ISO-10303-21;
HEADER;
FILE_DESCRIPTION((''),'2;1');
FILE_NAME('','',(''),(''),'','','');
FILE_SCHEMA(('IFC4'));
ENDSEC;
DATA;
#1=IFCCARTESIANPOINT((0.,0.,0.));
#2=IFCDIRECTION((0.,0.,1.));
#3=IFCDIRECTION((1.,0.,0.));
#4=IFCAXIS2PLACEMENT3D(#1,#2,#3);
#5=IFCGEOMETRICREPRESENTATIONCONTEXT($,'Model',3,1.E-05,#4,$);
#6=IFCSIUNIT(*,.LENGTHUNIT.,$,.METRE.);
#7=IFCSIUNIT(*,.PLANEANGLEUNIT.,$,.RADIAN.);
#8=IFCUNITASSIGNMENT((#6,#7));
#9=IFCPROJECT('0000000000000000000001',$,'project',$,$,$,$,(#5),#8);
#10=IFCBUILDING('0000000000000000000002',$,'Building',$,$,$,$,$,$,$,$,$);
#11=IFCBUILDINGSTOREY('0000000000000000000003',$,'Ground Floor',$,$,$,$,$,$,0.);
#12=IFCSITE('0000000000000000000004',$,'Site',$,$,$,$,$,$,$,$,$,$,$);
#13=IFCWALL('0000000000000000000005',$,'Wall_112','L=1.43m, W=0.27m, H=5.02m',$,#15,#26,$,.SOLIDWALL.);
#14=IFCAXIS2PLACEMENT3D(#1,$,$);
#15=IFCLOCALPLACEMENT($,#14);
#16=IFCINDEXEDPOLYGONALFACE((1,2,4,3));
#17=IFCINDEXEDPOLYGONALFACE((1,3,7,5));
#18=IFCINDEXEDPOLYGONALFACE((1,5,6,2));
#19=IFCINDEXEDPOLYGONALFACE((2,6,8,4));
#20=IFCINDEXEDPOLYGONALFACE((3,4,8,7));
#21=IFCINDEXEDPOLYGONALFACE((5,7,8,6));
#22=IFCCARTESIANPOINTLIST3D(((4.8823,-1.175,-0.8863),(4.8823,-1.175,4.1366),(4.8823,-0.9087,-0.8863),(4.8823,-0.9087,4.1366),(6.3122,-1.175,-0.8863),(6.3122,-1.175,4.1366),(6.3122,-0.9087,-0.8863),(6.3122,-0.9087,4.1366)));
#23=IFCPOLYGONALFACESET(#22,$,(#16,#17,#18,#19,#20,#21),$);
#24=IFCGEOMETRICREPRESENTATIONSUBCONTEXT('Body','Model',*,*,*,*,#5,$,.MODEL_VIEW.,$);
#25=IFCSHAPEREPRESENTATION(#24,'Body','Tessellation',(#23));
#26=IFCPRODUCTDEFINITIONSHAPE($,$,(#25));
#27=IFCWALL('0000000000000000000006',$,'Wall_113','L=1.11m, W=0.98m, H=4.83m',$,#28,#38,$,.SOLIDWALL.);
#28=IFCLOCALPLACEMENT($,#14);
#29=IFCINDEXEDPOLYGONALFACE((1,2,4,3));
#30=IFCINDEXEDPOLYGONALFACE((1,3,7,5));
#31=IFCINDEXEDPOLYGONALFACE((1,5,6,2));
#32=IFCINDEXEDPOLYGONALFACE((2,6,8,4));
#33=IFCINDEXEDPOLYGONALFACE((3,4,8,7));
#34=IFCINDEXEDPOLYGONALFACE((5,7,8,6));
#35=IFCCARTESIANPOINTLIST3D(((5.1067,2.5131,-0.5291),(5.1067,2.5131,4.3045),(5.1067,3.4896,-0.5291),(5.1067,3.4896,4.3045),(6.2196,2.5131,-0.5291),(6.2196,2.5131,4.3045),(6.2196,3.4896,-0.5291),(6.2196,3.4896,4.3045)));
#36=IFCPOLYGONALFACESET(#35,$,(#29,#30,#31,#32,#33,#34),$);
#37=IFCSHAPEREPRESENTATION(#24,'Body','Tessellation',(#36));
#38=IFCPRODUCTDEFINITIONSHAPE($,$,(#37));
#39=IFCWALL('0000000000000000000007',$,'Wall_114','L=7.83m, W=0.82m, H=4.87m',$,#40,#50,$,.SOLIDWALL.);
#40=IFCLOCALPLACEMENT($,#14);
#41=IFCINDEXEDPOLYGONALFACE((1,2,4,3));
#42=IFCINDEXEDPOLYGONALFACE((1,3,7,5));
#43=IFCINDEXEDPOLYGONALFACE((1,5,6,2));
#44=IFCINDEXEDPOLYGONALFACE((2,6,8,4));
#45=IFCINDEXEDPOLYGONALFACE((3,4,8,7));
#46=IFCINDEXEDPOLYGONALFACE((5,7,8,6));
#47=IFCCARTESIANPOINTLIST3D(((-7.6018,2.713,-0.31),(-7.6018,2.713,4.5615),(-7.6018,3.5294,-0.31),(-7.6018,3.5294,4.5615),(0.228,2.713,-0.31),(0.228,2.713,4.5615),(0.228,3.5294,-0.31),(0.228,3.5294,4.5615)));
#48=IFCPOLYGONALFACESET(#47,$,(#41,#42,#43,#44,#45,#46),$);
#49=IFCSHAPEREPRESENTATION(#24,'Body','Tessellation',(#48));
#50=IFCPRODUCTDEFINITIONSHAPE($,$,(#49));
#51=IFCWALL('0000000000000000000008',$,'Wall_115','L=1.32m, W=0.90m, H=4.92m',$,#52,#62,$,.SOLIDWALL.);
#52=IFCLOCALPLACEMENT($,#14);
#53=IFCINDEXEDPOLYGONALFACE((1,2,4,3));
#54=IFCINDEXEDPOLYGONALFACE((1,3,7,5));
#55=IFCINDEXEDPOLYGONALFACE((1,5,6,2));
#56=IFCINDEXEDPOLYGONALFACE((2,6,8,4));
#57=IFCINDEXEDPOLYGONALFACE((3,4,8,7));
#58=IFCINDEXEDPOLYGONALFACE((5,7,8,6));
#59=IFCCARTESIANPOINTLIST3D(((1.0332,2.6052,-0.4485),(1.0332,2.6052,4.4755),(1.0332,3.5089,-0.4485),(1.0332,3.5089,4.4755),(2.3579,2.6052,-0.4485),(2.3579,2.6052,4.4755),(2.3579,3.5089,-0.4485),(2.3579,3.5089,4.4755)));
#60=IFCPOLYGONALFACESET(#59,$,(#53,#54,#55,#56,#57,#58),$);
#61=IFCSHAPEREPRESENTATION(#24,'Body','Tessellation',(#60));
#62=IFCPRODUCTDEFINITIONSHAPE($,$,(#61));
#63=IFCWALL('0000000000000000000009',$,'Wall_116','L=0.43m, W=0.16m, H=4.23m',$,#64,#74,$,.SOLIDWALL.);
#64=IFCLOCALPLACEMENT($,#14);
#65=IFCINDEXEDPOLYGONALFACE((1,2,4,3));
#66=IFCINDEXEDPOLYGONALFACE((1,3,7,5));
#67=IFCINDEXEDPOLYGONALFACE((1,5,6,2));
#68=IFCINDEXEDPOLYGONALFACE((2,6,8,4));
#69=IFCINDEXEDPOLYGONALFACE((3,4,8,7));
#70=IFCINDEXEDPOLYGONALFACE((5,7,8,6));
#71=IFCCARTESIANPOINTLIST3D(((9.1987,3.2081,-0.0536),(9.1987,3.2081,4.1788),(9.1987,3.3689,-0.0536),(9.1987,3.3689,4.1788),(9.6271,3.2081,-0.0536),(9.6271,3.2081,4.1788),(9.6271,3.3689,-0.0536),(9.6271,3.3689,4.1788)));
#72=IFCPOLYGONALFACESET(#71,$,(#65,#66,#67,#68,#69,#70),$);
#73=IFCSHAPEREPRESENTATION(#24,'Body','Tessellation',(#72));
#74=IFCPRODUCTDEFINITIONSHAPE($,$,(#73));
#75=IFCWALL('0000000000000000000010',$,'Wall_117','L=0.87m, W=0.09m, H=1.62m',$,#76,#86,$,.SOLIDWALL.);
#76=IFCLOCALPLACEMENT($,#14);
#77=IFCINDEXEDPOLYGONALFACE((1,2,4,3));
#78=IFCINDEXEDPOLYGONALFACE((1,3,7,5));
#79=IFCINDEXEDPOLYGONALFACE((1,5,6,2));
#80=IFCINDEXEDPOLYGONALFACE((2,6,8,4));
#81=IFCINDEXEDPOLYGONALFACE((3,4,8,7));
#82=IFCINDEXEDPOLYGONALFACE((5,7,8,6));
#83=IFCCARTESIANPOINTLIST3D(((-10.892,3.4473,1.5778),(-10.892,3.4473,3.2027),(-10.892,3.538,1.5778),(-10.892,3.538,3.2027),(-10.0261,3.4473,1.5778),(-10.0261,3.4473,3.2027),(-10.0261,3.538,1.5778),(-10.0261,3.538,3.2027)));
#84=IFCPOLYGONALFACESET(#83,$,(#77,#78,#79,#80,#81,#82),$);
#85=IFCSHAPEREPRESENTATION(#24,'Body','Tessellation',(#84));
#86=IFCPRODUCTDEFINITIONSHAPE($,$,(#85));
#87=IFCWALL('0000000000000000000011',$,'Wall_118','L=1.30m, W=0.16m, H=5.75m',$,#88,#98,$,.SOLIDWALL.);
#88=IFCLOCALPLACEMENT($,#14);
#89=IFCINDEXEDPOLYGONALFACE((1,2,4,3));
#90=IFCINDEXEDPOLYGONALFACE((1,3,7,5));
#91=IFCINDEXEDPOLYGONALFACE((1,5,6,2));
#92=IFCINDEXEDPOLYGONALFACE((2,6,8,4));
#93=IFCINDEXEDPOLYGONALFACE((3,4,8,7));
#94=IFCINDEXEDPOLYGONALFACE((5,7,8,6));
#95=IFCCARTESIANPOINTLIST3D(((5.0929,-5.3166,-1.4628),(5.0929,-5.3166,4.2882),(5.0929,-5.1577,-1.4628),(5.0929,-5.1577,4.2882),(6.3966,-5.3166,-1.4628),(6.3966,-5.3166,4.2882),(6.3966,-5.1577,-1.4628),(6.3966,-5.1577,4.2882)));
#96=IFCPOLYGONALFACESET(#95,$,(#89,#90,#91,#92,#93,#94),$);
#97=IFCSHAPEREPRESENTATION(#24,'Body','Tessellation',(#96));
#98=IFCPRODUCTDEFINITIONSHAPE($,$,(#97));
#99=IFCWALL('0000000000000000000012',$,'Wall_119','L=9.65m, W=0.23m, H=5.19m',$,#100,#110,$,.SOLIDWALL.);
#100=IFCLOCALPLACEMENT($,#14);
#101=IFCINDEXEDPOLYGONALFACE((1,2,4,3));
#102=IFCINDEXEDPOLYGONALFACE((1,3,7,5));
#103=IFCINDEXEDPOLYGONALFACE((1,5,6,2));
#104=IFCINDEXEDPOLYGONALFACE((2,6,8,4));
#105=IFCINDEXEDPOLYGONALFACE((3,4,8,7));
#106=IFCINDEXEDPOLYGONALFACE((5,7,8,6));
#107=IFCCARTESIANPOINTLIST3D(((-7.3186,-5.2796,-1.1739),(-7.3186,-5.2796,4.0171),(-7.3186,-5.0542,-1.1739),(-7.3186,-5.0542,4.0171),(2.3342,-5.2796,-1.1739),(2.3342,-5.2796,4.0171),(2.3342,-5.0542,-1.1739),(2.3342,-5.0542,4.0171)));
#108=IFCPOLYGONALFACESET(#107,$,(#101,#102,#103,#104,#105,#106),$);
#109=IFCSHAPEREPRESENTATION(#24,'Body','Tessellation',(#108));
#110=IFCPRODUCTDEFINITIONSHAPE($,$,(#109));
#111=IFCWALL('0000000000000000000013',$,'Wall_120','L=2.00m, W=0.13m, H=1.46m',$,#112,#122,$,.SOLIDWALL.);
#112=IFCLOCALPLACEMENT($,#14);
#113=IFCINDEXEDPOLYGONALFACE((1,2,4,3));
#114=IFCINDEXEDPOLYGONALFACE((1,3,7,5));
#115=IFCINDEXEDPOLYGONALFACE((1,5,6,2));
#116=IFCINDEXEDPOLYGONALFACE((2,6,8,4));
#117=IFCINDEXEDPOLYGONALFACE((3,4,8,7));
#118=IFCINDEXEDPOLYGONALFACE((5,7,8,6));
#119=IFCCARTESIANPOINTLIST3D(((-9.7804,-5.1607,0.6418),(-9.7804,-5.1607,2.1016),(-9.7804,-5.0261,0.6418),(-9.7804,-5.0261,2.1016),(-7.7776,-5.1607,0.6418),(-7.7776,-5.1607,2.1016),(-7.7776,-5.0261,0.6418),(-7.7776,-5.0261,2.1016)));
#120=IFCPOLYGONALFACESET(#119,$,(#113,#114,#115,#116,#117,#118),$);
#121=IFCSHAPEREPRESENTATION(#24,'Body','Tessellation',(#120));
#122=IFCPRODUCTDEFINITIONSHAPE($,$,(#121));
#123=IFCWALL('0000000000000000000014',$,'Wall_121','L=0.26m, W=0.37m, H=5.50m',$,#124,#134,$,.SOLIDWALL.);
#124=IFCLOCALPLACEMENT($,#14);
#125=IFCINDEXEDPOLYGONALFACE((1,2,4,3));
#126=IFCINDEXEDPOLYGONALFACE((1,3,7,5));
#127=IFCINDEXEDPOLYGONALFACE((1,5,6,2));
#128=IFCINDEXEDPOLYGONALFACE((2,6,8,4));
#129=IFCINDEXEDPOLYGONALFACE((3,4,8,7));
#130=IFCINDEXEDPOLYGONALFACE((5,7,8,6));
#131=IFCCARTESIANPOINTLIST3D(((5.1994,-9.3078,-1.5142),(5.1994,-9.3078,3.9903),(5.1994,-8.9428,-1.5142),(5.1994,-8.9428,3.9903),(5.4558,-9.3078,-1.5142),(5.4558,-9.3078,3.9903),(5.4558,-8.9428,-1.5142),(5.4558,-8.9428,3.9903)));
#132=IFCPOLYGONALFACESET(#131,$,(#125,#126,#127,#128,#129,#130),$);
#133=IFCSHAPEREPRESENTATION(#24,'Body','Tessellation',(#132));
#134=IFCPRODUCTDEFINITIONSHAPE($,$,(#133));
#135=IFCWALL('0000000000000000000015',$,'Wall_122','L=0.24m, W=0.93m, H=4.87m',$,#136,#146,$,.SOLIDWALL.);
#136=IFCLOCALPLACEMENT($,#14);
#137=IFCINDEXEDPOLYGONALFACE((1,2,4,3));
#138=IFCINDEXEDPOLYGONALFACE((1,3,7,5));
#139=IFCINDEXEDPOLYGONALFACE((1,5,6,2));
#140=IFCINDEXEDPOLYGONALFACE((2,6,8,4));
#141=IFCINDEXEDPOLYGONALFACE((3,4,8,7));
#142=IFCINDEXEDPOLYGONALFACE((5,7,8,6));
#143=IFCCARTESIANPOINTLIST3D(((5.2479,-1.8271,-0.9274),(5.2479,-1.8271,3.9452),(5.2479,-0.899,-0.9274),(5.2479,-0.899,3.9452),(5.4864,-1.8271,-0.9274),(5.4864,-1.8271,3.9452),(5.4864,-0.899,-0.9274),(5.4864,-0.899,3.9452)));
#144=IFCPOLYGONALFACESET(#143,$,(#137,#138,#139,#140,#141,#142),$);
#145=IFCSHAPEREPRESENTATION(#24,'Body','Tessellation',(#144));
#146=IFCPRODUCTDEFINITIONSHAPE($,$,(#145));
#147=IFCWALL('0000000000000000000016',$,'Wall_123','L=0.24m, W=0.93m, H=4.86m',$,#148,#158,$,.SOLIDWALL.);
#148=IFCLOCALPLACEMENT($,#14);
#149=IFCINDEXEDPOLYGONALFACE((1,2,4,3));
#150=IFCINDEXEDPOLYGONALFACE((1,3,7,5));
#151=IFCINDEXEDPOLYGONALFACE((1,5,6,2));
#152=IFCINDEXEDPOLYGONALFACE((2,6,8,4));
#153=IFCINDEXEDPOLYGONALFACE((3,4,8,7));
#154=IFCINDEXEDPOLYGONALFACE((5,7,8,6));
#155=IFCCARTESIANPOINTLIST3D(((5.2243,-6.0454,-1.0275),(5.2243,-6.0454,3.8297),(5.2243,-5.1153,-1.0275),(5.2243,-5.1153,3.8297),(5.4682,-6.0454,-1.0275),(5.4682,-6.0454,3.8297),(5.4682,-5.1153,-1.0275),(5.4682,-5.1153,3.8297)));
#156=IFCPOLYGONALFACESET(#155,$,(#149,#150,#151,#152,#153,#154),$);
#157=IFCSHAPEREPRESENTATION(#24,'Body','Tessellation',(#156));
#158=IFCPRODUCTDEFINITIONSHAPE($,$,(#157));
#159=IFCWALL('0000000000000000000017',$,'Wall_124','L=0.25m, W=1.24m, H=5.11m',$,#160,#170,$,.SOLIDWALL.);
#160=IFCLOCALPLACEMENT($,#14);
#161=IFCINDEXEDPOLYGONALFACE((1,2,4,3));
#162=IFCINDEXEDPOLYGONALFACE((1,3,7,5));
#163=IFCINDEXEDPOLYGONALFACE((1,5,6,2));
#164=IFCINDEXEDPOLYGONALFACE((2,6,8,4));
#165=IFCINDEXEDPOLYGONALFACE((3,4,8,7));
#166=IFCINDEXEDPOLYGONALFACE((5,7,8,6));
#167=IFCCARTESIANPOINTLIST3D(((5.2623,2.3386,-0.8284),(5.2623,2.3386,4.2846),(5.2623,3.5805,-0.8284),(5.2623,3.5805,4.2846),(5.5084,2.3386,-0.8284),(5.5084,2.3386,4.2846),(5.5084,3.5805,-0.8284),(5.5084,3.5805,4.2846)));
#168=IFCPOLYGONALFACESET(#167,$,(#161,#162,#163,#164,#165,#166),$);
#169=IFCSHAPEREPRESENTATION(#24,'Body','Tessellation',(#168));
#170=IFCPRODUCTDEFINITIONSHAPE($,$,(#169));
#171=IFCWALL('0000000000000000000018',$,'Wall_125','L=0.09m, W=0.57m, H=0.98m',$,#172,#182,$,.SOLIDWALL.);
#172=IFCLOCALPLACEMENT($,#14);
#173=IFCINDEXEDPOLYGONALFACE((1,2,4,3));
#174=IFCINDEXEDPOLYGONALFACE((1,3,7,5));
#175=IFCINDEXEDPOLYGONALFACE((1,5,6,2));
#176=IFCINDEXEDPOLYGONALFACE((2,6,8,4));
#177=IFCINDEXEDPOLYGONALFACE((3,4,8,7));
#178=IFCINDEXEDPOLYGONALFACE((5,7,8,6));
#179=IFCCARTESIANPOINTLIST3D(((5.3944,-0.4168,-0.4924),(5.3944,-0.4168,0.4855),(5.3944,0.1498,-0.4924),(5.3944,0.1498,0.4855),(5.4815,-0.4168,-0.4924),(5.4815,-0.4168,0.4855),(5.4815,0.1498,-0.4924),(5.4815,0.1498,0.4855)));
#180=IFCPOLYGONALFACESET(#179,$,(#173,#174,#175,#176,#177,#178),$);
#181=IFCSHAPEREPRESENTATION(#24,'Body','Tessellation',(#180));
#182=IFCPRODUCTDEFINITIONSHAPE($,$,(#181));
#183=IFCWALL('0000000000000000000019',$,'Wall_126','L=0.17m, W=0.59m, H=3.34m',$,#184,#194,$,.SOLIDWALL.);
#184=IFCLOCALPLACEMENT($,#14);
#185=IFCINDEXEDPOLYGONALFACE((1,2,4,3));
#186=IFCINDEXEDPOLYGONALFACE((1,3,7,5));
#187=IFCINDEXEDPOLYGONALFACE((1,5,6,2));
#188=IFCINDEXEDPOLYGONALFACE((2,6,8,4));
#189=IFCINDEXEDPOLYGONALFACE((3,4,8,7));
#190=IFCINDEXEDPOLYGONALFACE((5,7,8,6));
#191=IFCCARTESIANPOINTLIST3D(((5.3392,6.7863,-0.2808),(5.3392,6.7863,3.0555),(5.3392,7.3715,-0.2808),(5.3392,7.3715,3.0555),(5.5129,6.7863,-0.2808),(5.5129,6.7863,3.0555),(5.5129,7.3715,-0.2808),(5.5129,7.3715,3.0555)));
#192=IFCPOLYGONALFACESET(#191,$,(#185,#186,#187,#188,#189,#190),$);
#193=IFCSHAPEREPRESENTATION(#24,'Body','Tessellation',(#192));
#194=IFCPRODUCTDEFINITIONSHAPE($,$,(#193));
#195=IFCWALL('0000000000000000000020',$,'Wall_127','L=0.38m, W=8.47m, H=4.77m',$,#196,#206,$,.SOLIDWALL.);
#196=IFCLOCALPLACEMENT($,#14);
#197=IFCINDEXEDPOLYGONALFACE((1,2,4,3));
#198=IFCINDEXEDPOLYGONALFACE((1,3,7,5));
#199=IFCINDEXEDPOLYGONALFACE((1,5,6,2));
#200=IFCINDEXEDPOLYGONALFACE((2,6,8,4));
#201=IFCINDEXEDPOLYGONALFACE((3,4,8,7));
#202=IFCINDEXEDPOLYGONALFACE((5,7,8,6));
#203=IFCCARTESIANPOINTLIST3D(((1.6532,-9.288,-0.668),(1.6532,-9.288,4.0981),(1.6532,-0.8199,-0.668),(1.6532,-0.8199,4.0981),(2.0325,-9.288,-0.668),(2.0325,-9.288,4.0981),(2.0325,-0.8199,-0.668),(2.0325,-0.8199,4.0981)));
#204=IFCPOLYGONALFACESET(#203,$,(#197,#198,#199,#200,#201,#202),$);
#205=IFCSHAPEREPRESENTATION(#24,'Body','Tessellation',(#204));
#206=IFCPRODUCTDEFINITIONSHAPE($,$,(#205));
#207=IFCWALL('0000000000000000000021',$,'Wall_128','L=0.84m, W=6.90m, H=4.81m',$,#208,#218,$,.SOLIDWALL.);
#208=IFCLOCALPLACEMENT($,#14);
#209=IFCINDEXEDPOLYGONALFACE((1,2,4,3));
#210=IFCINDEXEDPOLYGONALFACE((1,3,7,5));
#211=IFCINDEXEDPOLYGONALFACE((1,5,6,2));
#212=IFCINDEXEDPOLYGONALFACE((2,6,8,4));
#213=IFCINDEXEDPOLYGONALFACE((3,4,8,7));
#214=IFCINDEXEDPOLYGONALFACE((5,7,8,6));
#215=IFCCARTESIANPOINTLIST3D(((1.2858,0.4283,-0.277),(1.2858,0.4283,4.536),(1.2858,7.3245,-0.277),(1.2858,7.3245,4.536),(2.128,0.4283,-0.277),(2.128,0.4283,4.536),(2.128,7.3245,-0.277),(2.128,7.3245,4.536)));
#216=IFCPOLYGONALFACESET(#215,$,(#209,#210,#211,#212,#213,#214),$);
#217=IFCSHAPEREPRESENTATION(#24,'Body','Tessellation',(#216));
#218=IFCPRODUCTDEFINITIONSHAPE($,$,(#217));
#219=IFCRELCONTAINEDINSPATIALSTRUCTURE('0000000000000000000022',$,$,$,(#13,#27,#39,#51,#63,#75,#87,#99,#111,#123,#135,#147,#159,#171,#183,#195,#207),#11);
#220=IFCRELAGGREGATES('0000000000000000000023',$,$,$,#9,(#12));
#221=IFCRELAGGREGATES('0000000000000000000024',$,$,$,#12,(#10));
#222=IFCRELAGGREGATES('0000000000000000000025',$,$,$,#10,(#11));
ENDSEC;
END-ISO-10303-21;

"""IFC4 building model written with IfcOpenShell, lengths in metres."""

from ifc_helpers import new_model, si_unit, frame, origin_with_axes, origin_2d, context, subcontext, project, spatial, rectangle, extrude, element, save


model = new_model("IFC4")

# Units and contexts
model_context = context("Model", 3, precision=1e-05, world=origin_with_axes())
body_context = subcontext(model_context, "Body", "Model", "MODEL_VIEW")
ifc_project = project(units=[si_unit("LENGTHUNIT", "METRE"), si_unit("PLANEANGLEUNIT", "RADIAN")], contexts=[model_context])

# Site, building, storey
site = spatial("IfcSite", under=ifc_project, Name="Site")
building = spatial("IfcBuilding", under=site, Name="Building")
storey = spatial("IfcBuildingStorey", under=building, Name="Ground Floor", Elevation=0.0)

# Walls
element("IfcWall", 1, inside=storey, Name="Wall_112", Description="L=1.43m, W=0.27m, H=5.02m", PredefinedType="SOLIDWALL", context=body_context, shape_type="SweptSolid", body=[
    extrude(rectangle(XDim=1.43, YDim=0.2663, at=origin_2d()), frame((5.5972, -1.0419, -0.8863), z_axis=(0.0, 0.0, 1.0), x_axis=(1.0, 0.0, 0.0)), (0.0, 0.0, 1.0), 5.0229),
])
element("IfcWall", 2, inside=storey, Name="Wall_113", Description="L=1.11m, W=0.98m, H=4.83m", PredefinedType="SOLIDWALL", context=body_context, shape_type="SweptSolid", body=[
    extrude(rectangle(XDim=1.1129, YDim=0.9766, at=origin_2d()), frame((5.6631, 3.0014, -0.5291), z_axis=(0.0, 0.0, 1.0), x_axis=(1.0, 0.0, 0.0)), (0.0, 0.0, 1.0), 4.8336),
])
element("IfcWall", 3, inside=storey, Name="Wall_114", Description="L=7.83m, W=0.82m, H=4.87m", PredefinedType="SOLIDWALL", context=body_context, shape_type="SweptSolid", body=[
    extrude(rectangle(XDim=7.8298, YDim=0.8164, at=origin_2d()), frame((-3.6869, 3.1212, -0.31), z_axis=(0.0, 0.0, 1.0), x_axis=(1.0, 0.0, 0.0)), (0.0, 0.0, 1.0), 4.8715),
])
element("IfcWall", 4, inside=storey, Name="Wall_115", Description="L=1.32m, W=0.90m, H=4.92m", PredefinedType="SOLIDWALL", context=body_context, shape_type="SweptSolid", body=[
    extrude(rectangle(XDim=1.3247, YDim=0.9036, at=origin_2d()), frame((1.6956, 3.057, -0.4485), z_axis=(0.0, 0.0, 1.0), x_axis=(1.0, 0.0, 0.0)), (0.0, 0.0, 1.0), 4.924),
])
element("IfcWall", 5, inside=storey, Name="Wall_116", Description="L=0.43m, W=0.16m, H=4.23m", PredefinedType="SOLIDWALL", context=body_context, shape_type="SweptSolid", body=[
    extrude(rectangle(XDim=0.4285, YDim=0.1607, at=origin_2d()), frame((9.4129, 3.2885, -0.0536), z_axis=(0.0, 0.0, 1.0), x_axis=(1.0, 0.0, 0.0)), (0.0, 0.0, 1.0), 4.2324),
])
element("IfcWall", 6, inside=storey, Name="Wall_117", Description="L=0.87m, W=0.09m, H=1.62m", PredefinedType="SOLIDWALL", context=body_context, shape_type="SweptSolid", body=[
    extrude(rectangle(XDim=0.8659, YDim=0.0907, at=origin_2d()), frame((-10.4591, 3.4926, 1.5778), z_axis=(0.0, 0.0, 1.0), x_axis=(1.0, 0.0, 0.0)), (0.0, 0.0, 1.0), 1.6249),
])
element("IfcWall", 7, inside=storey, Name="Wall_118", Description="L=1.30m, W=0.16m, H=5.75m", PredefinedType="SOLIDWALL", context=body_context, shape_type="SweptSolid", body=[
    extrude(rectangle(XDim=1.3037, YDim=0.1589, at=origin_2d()), frame((5.7448, -5.2371, -1.4628), z_axis=(0.0, 0.0, 1.0), x_axis=(1.0, 0.0, 0.0)), (0.0, 0.0, 1.0), 5.751),
])
element("IfcWall", 8, inside=storey, Name="Wall_119", Description="L=9.65m, W=0.23m, H=5.19m", PredefinedType="SOLIDWALL", context=body_context, shape_type="SweptSolid", body=[
    extrude(rectangle(XDim=9.6528, YDim=0.2254, at=origin_2d()), frame((-2.4922, -5.1669, -1.1739), z_axis=(0.0, 0.0, 1.0), x_axis=(1.0, 0.0, 0.0)), (0.0, 0.0, 1.0), 5.191),
])
element("IfcWall", 9, inside=storey, Name="Wall_120", Description="L=2.00m, W=0.13m, H=1.46m", PredefinedType="SOLIDWALL", context=body_context, shape_type="SweptSolid", body=[
    extrude(rectangle(XDim=2.0028, YDim=0.1346, at=origin_2d()), frame((-8.779, -5.0934, 0.6418), z_axis=(0.0, 0.0, 1.0), x_axis=(1.0, 0.0, 0.0)), (0.0, 0.0, 1.0), 1.4598),
])
element("IfcWall", 10, inside=storey, Name="Wall_121", Description="L=0.26m, W=0.37m, H=5.50m", PredefinedType="SOLIDWALL", context=body_context, shape_type="SweptSolid", body=[
    extrude(rectangle(XDim=0.2563, YDim=0.365, at=origin_2d()), frame((5.3276, -9.1253, -1.5142), z_axis=(0.0, 0.0, 1.0), x_axis=(1.0, 0.0, 0.0)), (0.0, 0.0, 1.0), 5.5045),
])
element("IfcWall", 11, inside=storey, Name="Wall_122", Description="L=0.24m, W=0.93m, H=4.87m", PredefinedType="SOLIDWALL", context=body_context, shape_type="SweptSolid", body=[
    extrude(rectangle(XDim=0.2385, YDim=0.9281, at=origin_2d()), frame((5.3671, -1.3631, -0.9274), z_axis=(0.0, 0.0, 1.0), x_axis=(1.0, 0.0, 0.0)), (0.0, 0.0, 1.0), 4.8725),
])
element("IfcWall", 12, inside=storey, Name="Wall_123", Description="L=0.24m, W=0.93m, H=4.86m", PredefinedType="SOLIDWALL", context=body_context, shape_type="SweptSolid", body=[
    extrude(rectangle(XDim=0.2439, YDim=0.9301, at=origin_2d()), frame((5.3463, -5.5804, -1.0275), z_axis=(0.0, 0.0, 1.0), x_axis=(1.0, 0.0, 0.0)), (0.0, 0.0, 1.0), 4.8572),
])
element("IfcWall", 13, inside=storey, Name="Wall_124", Description="L=0.25m, W=1.24m, H=5.11m", PredefinedType="SOLIDWALL", context=body_context, shape_type="SweptSolid", body=[
    extrude(rectangle(XDim=0.2461, YDim=1.2418, at=origin_2d()), frame((5.3853, 2.9595, -0.8284), z_axis=(0.0, 0.0, 1.0), x_axis=(1.0, 0.0, 0.0)), (0.0, 0.0, 1.0), 5.113),
])
element("IfcWall", 14, inside=storey, Name="Wall_125", Description="L=0.09m, W=0.57m, H=0.98m", PredefinedType="SOLIDWALL", context=body_context, shape_type="SweptSolid", body=[
    extrude(rectangle(XDim=0.0871, YDim=0.5666, at=origin_2d()), frame((5.438, -0.1335, -0.4924), z_axis=(0.0, 0.0, 1.0), x_axis=(1.0, 0.0, 0.0)), (0.0, 0.0, 1.0), 0.9779),
])
element("IfcWall", 15, inside=storey, Name="Wall_126", Description="L=0.17m, W=0.59m, H=3.34m", PredefinedType="SOLIDWALL", context=body_context, shape_type="SweptSolid", body=[
    extrude(rectangle(XDim=0.1738, YDim=0.5852, at=origin_2d()), frame((5.4261, 7.0789, -0.2808), z_axis=(0.0, 0.0, 1.0), x_axis=(1.0, 0.0, 0.0)), (0.0, 0.0, 1.0), 3.3363),
])
element("IfcWall", 16, inside=storey, Name="Wall_127", Description="L=0.38m, W=8.47m, H=4.77m", PredefinedType="SOLIDWALL", context=body_context, shape_type="SweptSolid", body=[
    extrude(rectangle(XDim=0.3793, YDim=8.4681, at=origin_2d()), frame((1.8429, -5.054, -0.668), z_axis=(0.0, 0.0, 1.0), x_axis=(1.0, 0.0, 0.0)), (0.0, 0.0, 1.0), 4.7661),
])
element("IfcWall", 17, inside=storey, Name="Wall_128", Description="L=0.84m, W=6.90m, H=4.81m", PredefinedType="SOLIDWALL", context=body_context, shape_type="SweptSolid", body=[
    extrude(rectangle(XDim=0.8422, YDim=6.8962, at=origin_2d()), frame((1.7069, 3.8764, -0.277), z_axis=(0.0, 0.0, 1.0), x_axis=(1.0, 0.0, 0.0)), (0.0, 0.0, 1.0), 4.8129),
])

save(model, "model.ifc")
